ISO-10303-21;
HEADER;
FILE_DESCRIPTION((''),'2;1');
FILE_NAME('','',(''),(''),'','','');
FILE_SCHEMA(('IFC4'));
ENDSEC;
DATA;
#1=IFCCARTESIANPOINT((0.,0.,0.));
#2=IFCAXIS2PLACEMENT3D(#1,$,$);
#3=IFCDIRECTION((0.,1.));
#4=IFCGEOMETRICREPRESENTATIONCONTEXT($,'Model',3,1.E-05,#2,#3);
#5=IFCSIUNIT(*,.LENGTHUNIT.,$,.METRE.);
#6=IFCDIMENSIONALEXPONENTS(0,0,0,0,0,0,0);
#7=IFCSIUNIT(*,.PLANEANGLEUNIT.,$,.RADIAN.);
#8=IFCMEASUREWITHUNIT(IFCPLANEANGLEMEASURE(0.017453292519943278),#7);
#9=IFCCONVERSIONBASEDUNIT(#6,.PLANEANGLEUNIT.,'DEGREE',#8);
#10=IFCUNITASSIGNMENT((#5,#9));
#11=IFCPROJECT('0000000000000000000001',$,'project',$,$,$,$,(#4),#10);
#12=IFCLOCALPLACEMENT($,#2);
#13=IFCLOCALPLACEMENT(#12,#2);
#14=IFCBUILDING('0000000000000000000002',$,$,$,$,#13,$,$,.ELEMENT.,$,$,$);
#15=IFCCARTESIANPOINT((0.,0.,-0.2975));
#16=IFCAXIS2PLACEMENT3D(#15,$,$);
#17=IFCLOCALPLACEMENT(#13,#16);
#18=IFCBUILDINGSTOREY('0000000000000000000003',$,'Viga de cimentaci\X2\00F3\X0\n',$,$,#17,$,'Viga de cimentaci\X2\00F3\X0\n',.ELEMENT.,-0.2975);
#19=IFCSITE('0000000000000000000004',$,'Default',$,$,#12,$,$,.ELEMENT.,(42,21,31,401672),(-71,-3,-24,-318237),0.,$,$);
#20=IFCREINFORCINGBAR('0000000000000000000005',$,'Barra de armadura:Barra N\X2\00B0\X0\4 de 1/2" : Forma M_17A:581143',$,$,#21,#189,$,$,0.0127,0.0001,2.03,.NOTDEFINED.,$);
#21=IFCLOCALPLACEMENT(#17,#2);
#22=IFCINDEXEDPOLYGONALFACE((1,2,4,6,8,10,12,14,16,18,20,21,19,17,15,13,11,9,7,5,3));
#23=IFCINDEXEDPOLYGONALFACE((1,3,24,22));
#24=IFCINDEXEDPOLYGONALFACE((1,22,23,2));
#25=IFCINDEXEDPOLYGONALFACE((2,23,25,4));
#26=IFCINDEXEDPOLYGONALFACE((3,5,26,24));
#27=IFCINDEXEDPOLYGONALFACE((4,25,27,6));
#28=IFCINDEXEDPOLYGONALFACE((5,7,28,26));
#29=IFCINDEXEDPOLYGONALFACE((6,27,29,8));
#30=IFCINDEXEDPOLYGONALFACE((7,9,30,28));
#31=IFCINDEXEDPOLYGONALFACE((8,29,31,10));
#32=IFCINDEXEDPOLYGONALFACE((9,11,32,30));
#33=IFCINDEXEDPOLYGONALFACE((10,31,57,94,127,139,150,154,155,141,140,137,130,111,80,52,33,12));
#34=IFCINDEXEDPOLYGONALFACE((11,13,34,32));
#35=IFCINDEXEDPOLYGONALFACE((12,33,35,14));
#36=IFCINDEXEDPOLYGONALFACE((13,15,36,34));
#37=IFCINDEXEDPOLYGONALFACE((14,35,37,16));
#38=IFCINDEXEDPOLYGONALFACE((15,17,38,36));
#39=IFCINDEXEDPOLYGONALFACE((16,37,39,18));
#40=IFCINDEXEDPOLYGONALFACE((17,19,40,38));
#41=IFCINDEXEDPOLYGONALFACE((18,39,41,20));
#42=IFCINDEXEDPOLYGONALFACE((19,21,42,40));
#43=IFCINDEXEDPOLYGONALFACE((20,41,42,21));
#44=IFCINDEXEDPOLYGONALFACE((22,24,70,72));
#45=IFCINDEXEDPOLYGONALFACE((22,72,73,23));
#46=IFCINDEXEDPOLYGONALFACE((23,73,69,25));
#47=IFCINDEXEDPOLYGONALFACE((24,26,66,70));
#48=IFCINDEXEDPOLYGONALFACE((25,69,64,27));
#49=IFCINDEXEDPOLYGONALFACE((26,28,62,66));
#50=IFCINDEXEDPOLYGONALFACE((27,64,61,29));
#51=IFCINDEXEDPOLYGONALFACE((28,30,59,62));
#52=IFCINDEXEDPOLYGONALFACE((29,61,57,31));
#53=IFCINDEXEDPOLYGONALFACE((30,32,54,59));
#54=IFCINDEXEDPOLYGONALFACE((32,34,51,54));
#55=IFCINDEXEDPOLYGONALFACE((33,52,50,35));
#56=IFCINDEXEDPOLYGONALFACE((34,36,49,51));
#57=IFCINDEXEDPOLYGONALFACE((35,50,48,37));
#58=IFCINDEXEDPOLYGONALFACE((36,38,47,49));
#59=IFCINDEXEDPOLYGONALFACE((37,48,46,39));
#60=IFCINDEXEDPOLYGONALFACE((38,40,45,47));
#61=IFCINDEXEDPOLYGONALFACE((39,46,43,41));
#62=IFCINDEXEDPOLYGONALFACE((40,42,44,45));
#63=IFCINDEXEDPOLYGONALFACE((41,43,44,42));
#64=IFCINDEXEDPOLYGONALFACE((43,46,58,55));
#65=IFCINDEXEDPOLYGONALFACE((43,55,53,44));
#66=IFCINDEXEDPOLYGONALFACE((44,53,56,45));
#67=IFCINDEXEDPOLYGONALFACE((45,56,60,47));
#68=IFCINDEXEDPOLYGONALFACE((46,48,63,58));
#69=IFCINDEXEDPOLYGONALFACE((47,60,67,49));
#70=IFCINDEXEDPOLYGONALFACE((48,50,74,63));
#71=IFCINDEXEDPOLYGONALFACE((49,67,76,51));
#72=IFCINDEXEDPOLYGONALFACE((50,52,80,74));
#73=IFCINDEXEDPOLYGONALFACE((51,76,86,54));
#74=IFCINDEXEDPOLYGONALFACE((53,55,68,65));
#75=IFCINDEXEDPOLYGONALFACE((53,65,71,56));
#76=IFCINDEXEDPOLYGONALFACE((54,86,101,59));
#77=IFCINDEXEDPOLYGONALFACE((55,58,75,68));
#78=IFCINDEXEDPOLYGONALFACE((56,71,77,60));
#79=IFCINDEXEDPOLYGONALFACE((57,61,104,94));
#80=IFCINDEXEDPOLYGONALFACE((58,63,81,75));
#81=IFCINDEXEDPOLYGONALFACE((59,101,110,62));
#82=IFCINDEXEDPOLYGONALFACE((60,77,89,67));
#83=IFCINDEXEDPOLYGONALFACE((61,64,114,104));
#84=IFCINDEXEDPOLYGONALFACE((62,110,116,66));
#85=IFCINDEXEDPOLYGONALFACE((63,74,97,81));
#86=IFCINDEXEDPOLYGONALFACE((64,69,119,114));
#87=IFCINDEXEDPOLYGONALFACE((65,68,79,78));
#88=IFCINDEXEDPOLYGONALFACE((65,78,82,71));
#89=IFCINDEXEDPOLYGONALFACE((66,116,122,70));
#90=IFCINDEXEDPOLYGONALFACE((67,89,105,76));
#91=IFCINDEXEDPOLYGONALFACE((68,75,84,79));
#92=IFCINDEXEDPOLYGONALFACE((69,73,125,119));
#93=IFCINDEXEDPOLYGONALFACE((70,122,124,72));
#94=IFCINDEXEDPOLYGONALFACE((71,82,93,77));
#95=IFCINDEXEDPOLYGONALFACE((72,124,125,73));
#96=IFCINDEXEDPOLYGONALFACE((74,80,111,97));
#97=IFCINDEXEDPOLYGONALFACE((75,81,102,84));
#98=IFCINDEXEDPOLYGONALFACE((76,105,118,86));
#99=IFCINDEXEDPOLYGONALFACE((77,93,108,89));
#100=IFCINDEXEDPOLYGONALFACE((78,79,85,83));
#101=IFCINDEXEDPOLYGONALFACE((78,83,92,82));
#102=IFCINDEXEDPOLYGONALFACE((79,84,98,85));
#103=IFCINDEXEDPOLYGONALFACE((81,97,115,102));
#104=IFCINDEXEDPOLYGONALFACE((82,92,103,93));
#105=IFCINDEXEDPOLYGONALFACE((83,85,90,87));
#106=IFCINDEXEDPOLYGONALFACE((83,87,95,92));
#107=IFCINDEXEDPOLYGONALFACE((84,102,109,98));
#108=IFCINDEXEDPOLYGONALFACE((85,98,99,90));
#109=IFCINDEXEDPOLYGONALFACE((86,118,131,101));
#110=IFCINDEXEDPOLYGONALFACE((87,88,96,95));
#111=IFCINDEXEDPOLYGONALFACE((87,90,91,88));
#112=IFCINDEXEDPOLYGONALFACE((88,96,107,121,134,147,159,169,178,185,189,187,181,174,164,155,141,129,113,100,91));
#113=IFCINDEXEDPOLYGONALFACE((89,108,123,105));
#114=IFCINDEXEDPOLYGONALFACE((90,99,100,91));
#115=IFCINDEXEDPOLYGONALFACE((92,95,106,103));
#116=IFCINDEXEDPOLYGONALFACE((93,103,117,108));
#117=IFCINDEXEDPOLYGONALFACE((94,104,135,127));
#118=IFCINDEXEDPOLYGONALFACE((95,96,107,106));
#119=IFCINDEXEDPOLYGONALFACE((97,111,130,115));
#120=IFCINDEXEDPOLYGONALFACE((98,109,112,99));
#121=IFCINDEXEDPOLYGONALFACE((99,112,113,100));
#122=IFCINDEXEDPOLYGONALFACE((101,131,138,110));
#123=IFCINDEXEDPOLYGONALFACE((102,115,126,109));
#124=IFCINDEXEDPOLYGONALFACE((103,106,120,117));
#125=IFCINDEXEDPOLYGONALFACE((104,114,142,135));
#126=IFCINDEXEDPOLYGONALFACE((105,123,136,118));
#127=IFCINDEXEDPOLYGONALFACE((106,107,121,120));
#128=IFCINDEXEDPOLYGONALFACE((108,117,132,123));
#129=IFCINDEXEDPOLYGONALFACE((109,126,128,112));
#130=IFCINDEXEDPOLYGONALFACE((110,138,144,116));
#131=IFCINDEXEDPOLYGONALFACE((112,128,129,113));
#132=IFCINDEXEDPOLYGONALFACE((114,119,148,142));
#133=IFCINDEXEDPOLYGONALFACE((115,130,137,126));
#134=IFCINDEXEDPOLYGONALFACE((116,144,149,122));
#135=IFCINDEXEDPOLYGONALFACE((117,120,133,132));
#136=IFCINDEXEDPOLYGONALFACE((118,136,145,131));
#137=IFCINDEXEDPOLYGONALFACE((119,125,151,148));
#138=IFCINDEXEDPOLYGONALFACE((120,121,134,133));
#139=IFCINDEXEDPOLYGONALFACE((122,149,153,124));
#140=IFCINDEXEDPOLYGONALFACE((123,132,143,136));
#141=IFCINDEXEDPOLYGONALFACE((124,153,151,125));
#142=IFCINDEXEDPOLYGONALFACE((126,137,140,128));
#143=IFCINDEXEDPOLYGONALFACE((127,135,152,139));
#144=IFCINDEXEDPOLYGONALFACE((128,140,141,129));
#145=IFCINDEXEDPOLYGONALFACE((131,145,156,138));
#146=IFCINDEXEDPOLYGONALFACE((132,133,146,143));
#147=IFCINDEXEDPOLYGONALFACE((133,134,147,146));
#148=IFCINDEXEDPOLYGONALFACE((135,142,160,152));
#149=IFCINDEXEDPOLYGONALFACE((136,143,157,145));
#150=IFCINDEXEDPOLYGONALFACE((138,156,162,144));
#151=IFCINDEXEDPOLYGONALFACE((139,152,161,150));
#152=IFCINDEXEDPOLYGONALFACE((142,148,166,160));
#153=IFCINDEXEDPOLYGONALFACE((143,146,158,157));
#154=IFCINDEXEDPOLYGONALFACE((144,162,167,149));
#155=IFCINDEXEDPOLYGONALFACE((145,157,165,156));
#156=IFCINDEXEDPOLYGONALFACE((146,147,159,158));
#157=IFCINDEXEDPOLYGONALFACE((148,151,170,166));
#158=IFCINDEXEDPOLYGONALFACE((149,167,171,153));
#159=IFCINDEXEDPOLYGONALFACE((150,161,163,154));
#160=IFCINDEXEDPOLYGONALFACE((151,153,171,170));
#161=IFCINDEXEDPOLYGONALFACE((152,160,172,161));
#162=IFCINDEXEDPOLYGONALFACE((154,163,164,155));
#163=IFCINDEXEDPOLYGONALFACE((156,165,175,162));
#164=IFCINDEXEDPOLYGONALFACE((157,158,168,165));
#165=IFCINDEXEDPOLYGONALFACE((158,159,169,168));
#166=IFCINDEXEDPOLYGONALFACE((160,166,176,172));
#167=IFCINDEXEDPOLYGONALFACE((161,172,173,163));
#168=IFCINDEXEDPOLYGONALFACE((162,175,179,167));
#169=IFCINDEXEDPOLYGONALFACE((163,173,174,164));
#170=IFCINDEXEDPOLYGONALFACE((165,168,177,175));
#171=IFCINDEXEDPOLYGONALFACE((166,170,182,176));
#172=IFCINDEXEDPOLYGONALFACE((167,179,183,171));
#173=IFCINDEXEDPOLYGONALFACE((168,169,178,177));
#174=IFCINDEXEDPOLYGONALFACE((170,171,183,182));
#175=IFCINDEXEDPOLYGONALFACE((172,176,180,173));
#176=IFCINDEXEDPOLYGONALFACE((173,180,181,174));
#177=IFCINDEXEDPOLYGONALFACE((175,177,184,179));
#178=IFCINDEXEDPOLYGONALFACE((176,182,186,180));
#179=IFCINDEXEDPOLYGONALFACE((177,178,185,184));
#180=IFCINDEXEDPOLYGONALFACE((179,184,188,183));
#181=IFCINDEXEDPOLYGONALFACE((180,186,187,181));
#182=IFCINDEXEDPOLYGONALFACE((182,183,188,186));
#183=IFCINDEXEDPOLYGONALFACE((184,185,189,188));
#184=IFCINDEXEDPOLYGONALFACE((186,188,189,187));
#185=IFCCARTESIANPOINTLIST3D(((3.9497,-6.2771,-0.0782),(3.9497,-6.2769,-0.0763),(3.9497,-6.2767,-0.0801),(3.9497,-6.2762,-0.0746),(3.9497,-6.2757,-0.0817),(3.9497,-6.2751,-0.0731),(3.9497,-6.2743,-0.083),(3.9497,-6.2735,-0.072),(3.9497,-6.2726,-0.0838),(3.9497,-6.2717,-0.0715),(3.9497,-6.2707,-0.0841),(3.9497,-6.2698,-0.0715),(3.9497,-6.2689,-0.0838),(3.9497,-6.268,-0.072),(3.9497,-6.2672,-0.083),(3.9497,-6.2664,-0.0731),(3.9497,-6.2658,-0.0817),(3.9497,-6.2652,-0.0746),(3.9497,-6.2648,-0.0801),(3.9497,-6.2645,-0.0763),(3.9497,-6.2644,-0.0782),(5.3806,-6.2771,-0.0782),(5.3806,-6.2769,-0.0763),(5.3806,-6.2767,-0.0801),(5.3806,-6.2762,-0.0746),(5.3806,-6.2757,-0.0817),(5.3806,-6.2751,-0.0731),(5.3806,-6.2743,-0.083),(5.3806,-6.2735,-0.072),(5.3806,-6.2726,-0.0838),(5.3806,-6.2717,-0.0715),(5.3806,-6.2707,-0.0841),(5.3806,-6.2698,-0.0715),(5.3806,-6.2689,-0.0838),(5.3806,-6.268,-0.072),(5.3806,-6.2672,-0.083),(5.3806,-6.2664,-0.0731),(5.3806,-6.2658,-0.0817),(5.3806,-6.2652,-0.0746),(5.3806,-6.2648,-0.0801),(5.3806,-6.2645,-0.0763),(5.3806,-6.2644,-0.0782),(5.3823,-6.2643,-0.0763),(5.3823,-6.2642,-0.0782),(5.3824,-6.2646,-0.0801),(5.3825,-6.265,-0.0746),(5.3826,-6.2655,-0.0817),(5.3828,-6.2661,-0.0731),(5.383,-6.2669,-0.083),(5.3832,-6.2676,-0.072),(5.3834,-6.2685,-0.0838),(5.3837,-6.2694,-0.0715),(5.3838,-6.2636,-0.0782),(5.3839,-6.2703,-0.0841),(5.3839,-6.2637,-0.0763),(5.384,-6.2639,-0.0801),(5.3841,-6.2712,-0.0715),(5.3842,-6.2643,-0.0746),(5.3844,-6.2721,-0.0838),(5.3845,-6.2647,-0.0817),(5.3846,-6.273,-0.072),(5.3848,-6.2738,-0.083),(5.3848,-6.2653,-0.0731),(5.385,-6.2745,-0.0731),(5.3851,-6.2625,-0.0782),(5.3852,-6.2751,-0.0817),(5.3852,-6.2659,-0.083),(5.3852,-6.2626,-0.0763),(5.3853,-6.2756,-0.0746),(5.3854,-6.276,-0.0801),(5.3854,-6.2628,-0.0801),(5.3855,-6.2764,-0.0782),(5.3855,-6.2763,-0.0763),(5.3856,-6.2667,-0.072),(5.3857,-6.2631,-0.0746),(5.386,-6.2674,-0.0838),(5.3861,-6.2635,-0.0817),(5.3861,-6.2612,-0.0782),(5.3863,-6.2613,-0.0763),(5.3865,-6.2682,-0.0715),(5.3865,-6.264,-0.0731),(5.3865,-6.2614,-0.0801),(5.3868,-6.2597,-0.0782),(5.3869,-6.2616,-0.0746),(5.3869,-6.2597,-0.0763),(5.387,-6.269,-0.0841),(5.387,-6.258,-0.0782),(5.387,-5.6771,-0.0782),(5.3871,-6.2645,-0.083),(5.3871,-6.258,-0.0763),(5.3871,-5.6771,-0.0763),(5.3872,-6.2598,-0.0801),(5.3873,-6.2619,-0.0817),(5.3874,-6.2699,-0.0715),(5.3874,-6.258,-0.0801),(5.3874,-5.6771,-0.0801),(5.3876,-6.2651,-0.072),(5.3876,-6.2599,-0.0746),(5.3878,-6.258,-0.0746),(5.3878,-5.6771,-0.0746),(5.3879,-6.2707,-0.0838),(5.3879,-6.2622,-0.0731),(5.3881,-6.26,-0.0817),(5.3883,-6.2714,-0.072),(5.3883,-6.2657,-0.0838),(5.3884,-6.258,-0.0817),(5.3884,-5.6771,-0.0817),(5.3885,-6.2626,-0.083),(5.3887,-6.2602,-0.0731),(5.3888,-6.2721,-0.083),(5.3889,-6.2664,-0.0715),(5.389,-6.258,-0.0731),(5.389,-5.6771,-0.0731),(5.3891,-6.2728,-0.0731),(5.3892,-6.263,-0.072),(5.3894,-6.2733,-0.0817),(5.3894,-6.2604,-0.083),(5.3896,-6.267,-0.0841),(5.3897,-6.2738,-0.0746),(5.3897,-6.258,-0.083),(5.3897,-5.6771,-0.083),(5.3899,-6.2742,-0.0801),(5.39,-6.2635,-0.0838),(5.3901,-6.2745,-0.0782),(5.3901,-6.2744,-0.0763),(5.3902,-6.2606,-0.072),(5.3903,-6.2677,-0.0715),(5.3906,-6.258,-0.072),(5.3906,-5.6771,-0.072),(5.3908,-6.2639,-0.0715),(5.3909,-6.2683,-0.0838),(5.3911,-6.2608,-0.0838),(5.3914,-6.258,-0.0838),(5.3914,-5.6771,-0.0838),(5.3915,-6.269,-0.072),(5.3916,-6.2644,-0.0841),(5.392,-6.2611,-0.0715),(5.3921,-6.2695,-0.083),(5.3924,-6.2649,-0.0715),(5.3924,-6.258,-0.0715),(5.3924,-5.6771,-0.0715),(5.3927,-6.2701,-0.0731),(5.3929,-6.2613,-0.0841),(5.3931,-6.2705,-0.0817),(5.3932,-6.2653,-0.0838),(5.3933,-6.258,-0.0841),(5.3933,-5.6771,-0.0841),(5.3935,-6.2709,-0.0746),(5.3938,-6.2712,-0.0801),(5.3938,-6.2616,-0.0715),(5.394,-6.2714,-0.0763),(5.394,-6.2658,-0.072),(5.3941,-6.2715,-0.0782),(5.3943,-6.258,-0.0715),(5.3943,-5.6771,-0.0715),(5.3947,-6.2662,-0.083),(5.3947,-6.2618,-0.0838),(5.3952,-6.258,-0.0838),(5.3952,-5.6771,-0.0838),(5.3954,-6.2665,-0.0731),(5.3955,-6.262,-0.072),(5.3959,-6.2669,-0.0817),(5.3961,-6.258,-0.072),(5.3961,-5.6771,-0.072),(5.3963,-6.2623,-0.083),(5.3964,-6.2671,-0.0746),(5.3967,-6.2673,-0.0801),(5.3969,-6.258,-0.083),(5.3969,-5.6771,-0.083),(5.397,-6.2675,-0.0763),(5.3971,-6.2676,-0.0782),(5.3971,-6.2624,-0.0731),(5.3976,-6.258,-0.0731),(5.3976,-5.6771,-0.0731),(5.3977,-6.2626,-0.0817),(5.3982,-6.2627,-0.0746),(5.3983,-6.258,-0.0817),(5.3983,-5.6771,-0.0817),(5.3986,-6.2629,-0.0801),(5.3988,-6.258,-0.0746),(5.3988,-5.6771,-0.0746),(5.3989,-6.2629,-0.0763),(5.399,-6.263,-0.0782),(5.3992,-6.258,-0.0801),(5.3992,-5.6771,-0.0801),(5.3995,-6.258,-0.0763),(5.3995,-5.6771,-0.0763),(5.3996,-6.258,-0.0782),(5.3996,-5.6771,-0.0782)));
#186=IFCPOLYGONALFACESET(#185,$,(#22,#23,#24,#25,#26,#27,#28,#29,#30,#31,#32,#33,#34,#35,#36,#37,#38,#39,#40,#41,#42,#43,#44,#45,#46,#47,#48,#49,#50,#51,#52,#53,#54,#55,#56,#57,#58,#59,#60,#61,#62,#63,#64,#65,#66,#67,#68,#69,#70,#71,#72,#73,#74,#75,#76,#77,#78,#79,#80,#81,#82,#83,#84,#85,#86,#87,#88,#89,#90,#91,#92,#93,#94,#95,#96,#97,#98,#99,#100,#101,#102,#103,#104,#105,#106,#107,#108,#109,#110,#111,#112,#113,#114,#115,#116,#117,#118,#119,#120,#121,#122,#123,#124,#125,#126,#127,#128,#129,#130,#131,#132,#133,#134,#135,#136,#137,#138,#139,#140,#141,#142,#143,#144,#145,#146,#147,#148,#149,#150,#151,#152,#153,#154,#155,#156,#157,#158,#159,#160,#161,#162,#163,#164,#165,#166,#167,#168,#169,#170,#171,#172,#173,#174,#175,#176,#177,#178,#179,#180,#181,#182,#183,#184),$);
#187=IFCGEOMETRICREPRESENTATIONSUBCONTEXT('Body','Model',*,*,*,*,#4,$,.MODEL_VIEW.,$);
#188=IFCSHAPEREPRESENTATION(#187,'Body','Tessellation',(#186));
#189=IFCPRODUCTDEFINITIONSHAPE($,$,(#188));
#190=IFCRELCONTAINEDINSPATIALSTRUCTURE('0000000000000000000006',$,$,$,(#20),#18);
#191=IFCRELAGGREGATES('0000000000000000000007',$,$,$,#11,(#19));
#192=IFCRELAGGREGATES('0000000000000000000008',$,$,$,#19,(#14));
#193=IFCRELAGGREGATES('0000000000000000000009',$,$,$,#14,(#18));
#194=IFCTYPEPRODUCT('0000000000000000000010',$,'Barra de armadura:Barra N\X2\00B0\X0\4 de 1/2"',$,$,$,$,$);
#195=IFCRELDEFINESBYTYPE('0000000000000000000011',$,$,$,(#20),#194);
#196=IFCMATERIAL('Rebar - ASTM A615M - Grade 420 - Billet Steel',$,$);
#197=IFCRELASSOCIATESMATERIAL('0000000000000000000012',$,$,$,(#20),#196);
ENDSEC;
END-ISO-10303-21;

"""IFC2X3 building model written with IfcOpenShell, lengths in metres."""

from ifc_helpers import new_model, entity, si_unit, converted_unit, direction, frame, origin, place, context, subcontext, project, spatial, material, type_object, element, save


model = new_model("IFC2X3")

# Units and contexts
model_context = context("Model", 3, precision=1e-05, world=origin(), true_north=direction((0.0, 1.0)))
body_context = subcontext(model_context, "Body", "Model", "MODEL_VIEW")
ifc_project = project(units=[si_unit("LENGTHUNIT", "METRE"), converted_unit("PLANEANGLEUNIT", "DEGREE", entity("IfcPlaneAngleMeasure", 0.017453292519943278), si_unit("PLANEANGLEUNIT", "RADIAN"), dimensions=[0, 0, 0, 0, 0, 0, 0])], contexts=[model_context])

# Site, building, storey
site_placement = place(None, origin())
site = spatial("IfcSite", under=ifc_project, at=site_placement, Name="Default", CompositionType="ELEMENT", RefLatitude=(42, 21, 31, 401672), RefLongitude=(-71, -3, -24, -318237), RefElevation=0.0)
building_placement = place(site_placement, origin())
building = spatial("IfcBuilding", under=site, at=building_placement, CompositionType="ELEMENT")
storey_placement = place(building_placement, frame((0.0, 0.0, -0.2975)))
storey = spatial("IfcBuildingStorey", under=building, at=storey_placement, Name="Viga de cimentación", LongName="Viga de cimentación", CompositionType="ELEMENT", Elevation=-0.2975)

# Reinforcing bar
ifc_material = material(Name="Rebar - ASTM A615M - Grade 420 - Billet Steel")
type_product_1 = type_object("IfcTypeProduct", Name="Barra de armadura:Barra N°4 de 1/2\"")
reinforcing_bar_1_placement = place(storey_placement, origin())
element("IfcReinforcingBar", 1, at=reinforcing_bar_1_placement, inside=storey, type_object=type_product_1, material=ifc_material, Name="Barra de armadura:Barra N°4 de 1/2\" : Forma M_17A:581143", BarLength=2.03, BarRole="NOTDEFINED", CrossSectionArea=0.0001, NominalDiameter=0.0127, context=body_context, shape_type="AdvancedSweptSolid", body=[
    entity("IfcSweptDiskSolid", entity("IfcCompositeCurve", [entity("IfcCompositeCurveSegment", "CONTINUOUS", True, entity("IfcPolyline", [entity("IfcCartesianPoint", [5.3933, -5.6771, -0.0777]), entity("IfcCartesianPoint", [5.3933, -6.258, -0.0777])])), entity("IfcCompositeCurveSegment", "CONTINUOUS", True, entity("IfcTrimmedCurve", entity("IfcCircle", entity("IfcAxis2Placement3D", entity("IfcCartesianPoint", [5.3806, -6.258, -0.0777]), entity("IfcDirection", [0.0, 0.0, -1.0]), entity("IfcDirection", [0.0, -1.0, 0.0])), 0.0127), [entity("IfcParameterValue", 270.0)], [entity("IfcParameterValue", 360.0)], True, "PARAMETER")), entity("IfcCompositeCurveSegment", "CONTINUOUS", True, entity("IfcPolyline", [entity("IfcCartesianPoint", [5.3806, -6.2707, -0.0777]), entity("IfcCartesianPoint", [3.9497, -6.2707, -0.0777])]))], False), 0.0063, None, 0.0, 92.0),
])

save(model, "model.ifc")
